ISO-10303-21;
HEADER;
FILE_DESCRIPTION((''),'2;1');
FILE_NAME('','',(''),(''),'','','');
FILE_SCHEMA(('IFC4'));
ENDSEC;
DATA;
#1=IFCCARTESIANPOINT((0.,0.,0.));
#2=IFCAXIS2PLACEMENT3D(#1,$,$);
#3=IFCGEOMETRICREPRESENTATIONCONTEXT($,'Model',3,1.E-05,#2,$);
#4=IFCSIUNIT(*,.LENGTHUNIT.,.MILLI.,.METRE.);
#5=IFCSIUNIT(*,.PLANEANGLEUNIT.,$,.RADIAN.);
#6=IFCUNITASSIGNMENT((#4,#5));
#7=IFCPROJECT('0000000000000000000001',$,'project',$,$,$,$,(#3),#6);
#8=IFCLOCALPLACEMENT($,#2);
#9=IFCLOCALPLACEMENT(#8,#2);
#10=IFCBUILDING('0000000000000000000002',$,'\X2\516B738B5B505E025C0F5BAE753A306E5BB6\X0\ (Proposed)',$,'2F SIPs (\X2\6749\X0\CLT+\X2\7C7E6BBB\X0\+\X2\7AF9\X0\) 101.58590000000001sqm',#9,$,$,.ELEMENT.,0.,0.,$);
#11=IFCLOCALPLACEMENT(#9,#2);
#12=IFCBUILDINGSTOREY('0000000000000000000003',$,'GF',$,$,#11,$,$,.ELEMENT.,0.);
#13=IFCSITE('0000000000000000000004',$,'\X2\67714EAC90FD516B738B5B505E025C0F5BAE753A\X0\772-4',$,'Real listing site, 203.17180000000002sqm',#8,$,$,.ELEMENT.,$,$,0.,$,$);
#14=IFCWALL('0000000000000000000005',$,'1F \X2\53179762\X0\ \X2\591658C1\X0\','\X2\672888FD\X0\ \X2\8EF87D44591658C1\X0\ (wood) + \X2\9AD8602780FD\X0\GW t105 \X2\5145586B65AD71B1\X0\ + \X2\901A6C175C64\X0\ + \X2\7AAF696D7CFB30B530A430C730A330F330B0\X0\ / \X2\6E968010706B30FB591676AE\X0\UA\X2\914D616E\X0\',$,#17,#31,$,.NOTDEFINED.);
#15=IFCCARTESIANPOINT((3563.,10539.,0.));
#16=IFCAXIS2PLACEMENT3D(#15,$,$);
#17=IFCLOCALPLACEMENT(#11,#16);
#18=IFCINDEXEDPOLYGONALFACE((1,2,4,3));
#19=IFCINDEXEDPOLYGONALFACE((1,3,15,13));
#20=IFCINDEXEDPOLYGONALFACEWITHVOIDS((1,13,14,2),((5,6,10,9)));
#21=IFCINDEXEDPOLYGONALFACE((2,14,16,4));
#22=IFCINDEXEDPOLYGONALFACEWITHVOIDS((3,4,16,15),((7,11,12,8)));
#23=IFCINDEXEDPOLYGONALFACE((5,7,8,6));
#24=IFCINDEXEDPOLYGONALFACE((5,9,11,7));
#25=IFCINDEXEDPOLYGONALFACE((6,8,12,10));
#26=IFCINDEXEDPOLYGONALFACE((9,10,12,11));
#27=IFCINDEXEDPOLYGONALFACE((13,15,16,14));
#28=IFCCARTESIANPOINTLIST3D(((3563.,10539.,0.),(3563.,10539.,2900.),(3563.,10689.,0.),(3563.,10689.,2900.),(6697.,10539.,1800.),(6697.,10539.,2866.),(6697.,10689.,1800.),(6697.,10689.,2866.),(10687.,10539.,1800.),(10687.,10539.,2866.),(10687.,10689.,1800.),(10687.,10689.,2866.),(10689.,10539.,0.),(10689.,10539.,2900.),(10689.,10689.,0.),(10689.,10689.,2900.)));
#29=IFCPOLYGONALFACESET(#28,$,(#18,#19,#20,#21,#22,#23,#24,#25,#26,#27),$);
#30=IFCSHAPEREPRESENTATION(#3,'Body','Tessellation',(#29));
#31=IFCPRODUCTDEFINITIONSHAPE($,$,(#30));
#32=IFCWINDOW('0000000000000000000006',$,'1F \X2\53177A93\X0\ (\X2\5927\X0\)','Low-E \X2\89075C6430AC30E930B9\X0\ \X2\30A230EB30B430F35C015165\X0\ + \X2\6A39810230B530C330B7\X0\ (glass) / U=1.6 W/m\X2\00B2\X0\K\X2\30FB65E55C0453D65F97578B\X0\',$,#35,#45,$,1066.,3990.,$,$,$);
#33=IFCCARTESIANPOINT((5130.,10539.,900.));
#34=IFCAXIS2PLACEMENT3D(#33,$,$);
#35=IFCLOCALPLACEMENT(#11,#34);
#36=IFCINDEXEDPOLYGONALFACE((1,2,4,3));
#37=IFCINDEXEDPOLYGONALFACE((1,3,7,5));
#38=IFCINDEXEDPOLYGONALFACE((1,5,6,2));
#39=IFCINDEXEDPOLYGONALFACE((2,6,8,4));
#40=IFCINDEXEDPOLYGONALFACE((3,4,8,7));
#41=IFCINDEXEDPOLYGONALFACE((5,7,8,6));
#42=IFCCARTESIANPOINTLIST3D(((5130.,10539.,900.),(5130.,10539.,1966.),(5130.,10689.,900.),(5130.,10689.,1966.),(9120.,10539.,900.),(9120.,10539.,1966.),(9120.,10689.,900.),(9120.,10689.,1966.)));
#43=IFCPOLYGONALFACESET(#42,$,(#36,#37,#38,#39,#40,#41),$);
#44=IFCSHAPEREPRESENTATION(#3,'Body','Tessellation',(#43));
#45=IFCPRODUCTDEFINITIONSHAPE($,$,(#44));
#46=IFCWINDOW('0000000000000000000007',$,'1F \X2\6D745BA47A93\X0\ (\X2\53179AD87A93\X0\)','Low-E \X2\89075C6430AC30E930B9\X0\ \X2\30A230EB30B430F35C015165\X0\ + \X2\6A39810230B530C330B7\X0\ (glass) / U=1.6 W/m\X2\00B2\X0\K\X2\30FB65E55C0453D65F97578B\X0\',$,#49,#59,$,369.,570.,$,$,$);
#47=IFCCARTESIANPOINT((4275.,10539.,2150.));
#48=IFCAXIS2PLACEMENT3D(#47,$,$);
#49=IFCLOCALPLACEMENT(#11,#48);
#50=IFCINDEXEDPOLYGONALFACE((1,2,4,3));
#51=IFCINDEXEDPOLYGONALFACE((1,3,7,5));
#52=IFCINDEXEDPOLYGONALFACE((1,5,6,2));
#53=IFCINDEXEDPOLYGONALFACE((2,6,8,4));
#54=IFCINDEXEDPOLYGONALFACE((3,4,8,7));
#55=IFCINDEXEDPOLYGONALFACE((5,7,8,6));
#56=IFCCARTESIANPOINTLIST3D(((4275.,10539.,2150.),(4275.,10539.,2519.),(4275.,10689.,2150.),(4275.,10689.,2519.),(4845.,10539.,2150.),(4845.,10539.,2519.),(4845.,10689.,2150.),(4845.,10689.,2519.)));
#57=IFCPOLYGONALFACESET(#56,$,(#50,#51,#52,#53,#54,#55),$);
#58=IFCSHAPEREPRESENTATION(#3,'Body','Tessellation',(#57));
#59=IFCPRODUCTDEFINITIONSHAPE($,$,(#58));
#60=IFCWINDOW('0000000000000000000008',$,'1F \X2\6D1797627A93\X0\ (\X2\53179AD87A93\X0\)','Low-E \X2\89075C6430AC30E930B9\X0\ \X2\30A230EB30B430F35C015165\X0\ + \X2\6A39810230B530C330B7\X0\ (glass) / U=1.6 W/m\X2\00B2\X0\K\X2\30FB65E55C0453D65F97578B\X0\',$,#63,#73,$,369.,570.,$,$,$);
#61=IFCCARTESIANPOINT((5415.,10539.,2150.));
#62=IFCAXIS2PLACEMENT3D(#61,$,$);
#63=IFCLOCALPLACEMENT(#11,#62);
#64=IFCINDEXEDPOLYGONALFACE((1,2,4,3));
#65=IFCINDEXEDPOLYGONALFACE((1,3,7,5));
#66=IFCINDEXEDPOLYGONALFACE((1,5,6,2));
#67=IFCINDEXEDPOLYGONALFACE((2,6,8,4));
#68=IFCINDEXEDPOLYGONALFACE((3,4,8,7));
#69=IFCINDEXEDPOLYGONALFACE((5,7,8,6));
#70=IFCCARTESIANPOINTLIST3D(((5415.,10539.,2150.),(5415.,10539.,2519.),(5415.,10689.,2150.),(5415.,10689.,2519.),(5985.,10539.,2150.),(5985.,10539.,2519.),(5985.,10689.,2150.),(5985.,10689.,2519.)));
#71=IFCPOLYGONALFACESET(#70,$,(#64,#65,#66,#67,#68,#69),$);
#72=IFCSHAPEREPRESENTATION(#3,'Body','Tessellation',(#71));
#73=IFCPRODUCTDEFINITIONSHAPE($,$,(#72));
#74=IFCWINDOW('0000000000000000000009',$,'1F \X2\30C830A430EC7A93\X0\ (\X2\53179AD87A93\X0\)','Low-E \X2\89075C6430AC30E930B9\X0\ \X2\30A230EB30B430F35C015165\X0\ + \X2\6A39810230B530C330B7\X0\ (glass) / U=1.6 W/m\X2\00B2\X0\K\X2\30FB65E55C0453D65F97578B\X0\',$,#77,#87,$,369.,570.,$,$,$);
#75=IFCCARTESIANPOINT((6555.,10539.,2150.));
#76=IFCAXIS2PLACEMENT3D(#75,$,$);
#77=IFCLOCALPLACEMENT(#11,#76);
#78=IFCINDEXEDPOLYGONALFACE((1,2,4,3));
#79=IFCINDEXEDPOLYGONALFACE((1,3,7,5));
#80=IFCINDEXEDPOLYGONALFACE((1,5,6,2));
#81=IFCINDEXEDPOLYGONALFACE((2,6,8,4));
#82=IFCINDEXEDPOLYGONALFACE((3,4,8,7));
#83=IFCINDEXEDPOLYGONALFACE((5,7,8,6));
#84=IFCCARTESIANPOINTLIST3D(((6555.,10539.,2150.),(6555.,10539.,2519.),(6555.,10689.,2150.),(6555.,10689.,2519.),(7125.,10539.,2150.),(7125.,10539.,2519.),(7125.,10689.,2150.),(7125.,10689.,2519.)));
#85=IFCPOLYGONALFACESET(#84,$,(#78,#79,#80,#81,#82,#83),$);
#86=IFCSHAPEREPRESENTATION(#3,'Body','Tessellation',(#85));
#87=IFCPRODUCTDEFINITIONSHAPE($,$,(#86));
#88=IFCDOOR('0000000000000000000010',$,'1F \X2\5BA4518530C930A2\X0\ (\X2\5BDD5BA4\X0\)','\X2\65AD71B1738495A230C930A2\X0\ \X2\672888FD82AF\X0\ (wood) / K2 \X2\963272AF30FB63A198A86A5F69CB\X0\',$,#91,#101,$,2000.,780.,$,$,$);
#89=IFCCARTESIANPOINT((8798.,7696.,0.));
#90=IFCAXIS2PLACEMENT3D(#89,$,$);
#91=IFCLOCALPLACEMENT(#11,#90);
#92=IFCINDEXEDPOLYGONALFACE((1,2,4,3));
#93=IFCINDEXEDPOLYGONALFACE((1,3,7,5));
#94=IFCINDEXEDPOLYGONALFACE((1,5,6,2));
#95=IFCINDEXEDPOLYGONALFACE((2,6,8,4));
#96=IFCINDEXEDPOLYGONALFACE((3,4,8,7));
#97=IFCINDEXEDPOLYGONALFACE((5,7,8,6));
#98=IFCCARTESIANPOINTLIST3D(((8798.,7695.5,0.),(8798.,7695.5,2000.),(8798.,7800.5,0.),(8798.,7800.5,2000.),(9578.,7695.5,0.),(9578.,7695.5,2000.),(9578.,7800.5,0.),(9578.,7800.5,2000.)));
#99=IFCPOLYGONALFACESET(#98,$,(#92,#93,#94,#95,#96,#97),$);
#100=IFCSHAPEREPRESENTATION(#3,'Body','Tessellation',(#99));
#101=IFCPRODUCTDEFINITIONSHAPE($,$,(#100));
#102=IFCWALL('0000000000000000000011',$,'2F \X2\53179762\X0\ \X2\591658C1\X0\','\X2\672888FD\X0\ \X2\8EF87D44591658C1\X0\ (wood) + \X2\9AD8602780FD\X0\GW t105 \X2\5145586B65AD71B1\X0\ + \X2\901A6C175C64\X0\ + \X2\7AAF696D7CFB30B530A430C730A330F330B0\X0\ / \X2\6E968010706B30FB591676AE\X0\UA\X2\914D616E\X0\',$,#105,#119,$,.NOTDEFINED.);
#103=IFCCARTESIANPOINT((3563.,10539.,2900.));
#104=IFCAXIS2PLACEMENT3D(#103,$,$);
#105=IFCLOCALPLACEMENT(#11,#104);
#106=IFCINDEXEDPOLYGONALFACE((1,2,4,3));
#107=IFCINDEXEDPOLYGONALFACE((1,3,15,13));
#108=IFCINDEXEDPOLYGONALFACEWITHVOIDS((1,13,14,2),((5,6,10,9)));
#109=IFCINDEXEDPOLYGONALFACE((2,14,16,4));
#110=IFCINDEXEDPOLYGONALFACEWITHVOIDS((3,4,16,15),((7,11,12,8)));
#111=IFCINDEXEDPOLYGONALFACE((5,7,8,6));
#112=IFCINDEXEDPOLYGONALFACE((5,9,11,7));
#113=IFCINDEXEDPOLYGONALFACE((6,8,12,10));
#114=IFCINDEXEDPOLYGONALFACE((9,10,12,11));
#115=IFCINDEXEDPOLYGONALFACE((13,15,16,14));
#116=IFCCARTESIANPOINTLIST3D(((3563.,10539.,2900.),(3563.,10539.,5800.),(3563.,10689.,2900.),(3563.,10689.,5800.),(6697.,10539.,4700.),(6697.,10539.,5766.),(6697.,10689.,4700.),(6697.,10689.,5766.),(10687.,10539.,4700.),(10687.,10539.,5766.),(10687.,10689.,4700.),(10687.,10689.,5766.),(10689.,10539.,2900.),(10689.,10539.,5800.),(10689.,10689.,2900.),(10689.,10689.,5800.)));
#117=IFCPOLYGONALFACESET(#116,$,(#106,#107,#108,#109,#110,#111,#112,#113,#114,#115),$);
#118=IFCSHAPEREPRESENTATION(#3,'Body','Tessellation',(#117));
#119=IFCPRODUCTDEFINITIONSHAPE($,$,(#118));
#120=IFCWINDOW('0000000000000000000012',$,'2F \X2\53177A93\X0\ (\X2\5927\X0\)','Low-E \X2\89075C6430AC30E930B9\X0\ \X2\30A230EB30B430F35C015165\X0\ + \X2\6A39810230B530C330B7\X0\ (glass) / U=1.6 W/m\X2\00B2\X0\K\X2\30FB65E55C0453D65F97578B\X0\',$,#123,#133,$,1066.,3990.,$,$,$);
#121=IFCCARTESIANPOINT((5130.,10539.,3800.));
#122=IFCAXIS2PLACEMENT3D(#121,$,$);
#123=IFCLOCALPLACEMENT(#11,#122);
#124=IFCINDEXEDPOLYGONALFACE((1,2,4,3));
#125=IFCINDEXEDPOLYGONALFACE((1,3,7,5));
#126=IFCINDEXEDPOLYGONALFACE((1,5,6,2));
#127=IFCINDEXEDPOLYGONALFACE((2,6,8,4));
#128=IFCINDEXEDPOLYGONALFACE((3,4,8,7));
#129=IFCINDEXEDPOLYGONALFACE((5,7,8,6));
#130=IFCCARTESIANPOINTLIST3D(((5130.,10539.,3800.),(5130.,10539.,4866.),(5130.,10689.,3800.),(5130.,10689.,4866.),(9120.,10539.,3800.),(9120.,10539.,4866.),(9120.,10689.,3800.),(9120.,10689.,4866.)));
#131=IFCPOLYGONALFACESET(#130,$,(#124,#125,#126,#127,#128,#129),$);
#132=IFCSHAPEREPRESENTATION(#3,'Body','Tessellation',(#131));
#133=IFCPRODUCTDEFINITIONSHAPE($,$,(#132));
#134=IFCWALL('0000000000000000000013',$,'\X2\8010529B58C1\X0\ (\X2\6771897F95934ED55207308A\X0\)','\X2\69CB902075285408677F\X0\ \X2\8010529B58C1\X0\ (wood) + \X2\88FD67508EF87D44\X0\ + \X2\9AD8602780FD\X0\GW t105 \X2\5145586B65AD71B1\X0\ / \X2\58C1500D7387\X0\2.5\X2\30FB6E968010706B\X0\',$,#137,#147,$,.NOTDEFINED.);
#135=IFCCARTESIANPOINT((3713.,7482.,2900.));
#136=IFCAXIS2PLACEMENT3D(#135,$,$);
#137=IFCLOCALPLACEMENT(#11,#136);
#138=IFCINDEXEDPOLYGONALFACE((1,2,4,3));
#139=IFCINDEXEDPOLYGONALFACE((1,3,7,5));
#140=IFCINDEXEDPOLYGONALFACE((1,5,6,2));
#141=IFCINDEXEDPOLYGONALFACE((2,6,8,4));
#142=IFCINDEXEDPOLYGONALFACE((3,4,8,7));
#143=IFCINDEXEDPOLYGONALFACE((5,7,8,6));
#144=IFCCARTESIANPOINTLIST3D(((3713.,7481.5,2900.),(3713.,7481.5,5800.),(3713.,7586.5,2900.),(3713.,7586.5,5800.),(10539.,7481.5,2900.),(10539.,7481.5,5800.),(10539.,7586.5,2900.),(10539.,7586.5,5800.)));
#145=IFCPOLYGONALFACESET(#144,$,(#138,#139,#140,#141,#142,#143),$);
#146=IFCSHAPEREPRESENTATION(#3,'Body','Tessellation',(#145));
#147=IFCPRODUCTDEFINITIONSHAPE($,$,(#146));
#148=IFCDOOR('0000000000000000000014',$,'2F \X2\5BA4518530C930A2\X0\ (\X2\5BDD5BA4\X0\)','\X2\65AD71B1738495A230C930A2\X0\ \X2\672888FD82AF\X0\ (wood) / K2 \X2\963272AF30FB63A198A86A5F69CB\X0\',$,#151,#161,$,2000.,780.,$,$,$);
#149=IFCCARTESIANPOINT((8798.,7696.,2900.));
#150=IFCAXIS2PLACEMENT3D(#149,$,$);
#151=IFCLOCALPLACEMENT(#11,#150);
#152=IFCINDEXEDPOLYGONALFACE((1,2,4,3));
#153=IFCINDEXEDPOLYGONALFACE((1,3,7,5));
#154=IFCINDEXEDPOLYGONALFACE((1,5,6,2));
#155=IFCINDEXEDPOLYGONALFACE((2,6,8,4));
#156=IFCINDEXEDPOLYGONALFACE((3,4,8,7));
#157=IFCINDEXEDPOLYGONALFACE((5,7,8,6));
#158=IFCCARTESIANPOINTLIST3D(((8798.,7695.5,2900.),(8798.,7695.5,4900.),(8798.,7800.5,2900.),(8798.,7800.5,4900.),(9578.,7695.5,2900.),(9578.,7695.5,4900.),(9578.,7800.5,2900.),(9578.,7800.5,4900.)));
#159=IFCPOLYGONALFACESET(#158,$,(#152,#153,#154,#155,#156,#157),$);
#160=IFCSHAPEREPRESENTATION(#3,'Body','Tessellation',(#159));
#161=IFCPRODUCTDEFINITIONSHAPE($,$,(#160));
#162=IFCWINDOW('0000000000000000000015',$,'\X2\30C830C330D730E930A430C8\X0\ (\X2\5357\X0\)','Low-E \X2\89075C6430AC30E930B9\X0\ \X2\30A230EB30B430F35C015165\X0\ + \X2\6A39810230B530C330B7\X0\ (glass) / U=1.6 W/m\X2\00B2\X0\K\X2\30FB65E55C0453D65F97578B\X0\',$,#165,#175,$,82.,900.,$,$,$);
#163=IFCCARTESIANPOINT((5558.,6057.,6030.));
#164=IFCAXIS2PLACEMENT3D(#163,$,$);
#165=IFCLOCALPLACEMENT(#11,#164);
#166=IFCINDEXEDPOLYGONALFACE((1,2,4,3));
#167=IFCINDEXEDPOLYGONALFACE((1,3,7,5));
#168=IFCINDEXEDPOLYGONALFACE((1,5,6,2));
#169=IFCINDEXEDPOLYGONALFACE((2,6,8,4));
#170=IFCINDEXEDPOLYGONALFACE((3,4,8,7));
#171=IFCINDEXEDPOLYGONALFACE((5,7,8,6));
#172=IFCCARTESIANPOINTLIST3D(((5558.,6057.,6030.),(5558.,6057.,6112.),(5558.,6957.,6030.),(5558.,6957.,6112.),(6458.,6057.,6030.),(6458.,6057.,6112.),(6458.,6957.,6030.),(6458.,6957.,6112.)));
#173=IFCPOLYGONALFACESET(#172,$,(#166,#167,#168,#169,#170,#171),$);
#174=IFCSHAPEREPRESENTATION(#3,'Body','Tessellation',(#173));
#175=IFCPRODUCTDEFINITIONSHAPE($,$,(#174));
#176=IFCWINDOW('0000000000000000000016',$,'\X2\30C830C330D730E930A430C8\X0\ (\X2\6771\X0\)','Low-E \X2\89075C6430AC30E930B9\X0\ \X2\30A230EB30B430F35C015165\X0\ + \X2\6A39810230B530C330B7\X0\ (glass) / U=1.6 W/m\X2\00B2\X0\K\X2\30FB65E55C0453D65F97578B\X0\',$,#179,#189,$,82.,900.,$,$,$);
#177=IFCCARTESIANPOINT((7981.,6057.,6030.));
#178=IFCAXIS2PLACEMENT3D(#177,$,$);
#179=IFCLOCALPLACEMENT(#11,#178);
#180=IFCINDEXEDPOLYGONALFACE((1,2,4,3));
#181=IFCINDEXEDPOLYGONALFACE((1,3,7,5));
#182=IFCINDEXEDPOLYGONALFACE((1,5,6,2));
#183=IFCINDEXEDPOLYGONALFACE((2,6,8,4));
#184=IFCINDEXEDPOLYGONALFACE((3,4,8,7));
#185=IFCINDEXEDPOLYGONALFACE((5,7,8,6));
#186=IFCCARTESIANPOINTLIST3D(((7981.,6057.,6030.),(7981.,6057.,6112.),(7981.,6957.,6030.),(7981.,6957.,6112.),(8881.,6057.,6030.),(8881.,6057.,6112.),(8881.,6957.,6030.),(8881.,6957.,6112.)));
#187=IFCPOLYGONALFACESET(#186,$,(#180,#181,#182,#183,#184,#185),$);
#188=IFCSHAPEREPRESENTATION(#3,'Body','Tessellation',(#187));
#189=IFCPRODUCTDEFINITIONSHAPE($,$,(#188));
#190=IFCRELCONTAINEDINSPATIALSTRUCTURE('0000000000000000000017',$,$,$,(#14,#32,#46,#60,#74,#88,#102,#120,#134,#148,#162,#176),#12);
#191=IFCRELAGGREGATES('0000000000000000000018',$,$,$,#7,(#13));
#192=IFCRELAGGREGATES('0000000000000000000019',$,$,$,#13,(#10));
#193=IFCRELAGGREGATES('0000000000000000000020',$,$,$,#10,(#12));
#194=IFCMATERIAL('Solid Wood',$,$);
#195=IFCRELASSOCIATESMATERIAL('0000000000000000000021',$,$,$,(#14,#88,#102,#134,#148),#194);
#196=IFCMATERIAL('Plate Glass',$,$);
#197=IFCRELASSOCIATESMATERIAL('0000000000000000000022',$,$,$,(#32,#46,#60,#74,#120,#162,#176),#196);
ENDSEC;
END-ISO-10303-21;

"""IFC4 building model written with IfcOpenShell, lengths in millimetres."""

from ifc_helpers import new_model, si_unit, frame, frame_2d, origin, place, context, project, spatial, rectangle, extrude, material, element, fill, save


model = new_model("IFC4")

# Units and contexts
model_context = context("Model", 3, precision=1e-05, world=origin())
ifc_project = project(units=[si_unit("LENGTHUNIT", "METRE", prefix="MILLI"), si_unit("PLANEANGLEUNIT", "RADIAN")], contexts=[model_context])

# Site, building, storey
site_placement = place(None, origin())
site = spatial("IfcSite", under=ifc_project, at=site_placement, Name="東京都八王子市小宮町772-4", ObjectType="Real listing site, 203.17180000000002sqm", CompositionType="ELEMENT", RefElevation=0.0)
building_placement = place(site_placement, origin())
building = spatial("IfcBuilding", under=site, at=building_placement, Name="八王子市小宮町の家 (Proposed)", ObjectType="2F SIPs (杉CLT+籾殻+竹) 101.58590000000001sqm", CompositionType="ELEMENT", ElevationOfRefHeight=0.0, ElevationOfTerrain=0.0)
storey_placement = place(building_placement, origin())
storey = spatial("IfcBuildingStorey", under=building, at=storey_placement, Name="GF", CompositionType="ELEMENT", Elevation=0.0)

# Wall, openings, windows
ifc_material_1 = material(Name="Solid Wood")
wall_1_placement = place(storey_placement, frame((3563.0, 10539.0, 0.0)))
wall_1 = element("IfcWall", 1, at=wall_1_placement, inside=storey, material=ifc_material_1, Name="1F 北面 外壁", Description="木製 軸組外壁 (wood) + 高性能GW t105 充填断熱 + 通気層 + 窯業系サイディング / 準耐火・外皮UA配慮", PredefinedType="NOTDEFINED", context=model_context, shape_type="SweptSolid", body=[
    extrude(rectangle(XDim=7126.0, YDim=150.0, at=frame_2d((3563.0, 75.0))), frame((3563.0, 10539.0, 0.0)), (0.0, 0.0, 1.0), 2900.0),
])
opening_1_placement = place(storey_placement, frame((5130.0, 10539.0, 900.0)))
opening_1 = element("IfcOpeningElement", 2, at=opening_1_placement, cuts=wall_1, PredefinedType="NOTDEFINED", context=model_context, shape_type="SweptSolid", body=[
    extrude(rectangle(XDim=3990.0, YDim=150.0, at=frame_2d((1995.0, 75.0))), frame((5130.0, 10539.0, 900.0)), (0.0, 0.0, 1.0), 1066.0),
])
opening_2_placement = place(storey_placement, frame((4275.0, 10539.0, 2150.0)))
opening_2 = element("IfcOpeningElement", 3, at=opening_2_placement, cuts=wall_1, PredefinedType="NOTDEFINED", context=model_context, shape_type="SweptSolid", body=[
    extrude(rectangle(XDim=570.0, YDim=150.0, at=frame_2d((285.0, 75.0))), frame((4275.0, 10539.0, 2150.0)), (0.0, 0.0, 1.0), 369.0),
])
opening_3_placement = place(storey_placement, frame((5415.0, 10539.0, 2150.0)))
opening_3 = element("IfcOpeningElement", 4, at=opening_3_placement, cuts=wall_1, PredefinedType="NOTDEFINED", context=model_context, shape_type="SweptSolid", body=[
    extrude(rectangle(XDim=570.0, YDim=150.0, at=frame_2d((285.0, 75.0))), frame((5415.0, 10539.0, 2150.0)), (0.0, 0.0, 1.0), 369.0),
])
opening_4_placement = place(storey_placement, frame((6555.0, 10539.0, 2150.0)))
opening_4 = element("IfcOpeningElement", 5, at=opening_4_placement, cuts=wall_1, PredefinedType="NOTDEFINED", context=model_context, shape_type="SweptSolid", body=[
    extrude(rectangle(XDim=570.0, YDim=150.0, at=frame_2d((285.0, 75.0))), frame((6555.0, 10539.0, 2150.0)), (0.0, 0.0, 1.0), 369.0),
])
ifc_material_2 = material(Name="Plate Glass")
window_1_placement = place(storey_placement, frame((5130.0, 10539.0, 900.0)))
window_1 = element("IfcWindow", 6, at=window_1_placement, inside=storey, material=ifc_material_2, Name="1F 北窓 (大)", Description="Low-E 複層ガラス アルゴン封入 + 樹脂サッシ (glass) / U=1.6 W/m²K・日射取得型", OverallHeight=1066.0, OverallWidth=3990.0, context=model_context, shape_type="SweptSolid", body=[
    extrude(rectangle(XDim=3990.0, YDim=150.0, at=frame_2d((1995.0, 75.0))), frame((5130.0, 10539.0, 900.0)), (0.0, 0.0, 1.0), 1066.0),
])
fill(opening_1, window_1)
window_2_placement = place(storey_placement, frame((4275.0, 10539.0, 2150.0)))
window_2 = element("IfcWindow", 7, at=window_2_placement, inside=storey, material=ifc_material_2, Name="1F 浴室窓 (北高窓)", Description="Low-E 複層ガラス アルゴン封入 + 樹脂サッシ (glass) / U=1.6 W/m²K・日射取得型", OverallHeight=369.0, OverallWidth=570.0, context=model_context, shape_type="SweptSolid", body=[
    extrude(rectangle(XDim=570.0, YDim=150.0, at=frame_2d((285.0, 75.0))), frame((4275.0, 10539.0, 2150.0)), (0.0, 0.0, 1.0), 369.0),
])
fill(opening_2, window_2)
window_3_placement = place(storey_placement, frame((5415.0, 10539.0, 2150.0)))
window_3 = element("IfcWindow", 8, at=window_3_placement, inside=storey, material=ifc_material_2, Name="1F 洗面窓 (北高窓)", Description="Low-E 複層ガラス アルゴン封入 + 樹脂サッシ (glass) / U=1.6 W/m²K・日射取得型", OverallHeight=369.0, OverallWidth=570.0, context=model_context, shape_type="SweptSolid", body=[
    extrude(rectangle(XDim=570.0, YDim=150.0, at=frame_2d((285.0, 75.0))), frame((5415.0, 10539.0, 2150.0)), (0.0, 0.0, 1.0), 369.0),
])
fill(opening_3, window_3)
window_4_placement = place(storey_placement, frame((6555.0, 10539.0, 2150.0)))
window_4 = element("IfcWindow", 9, at=window_4_placement, inside=storey, material=ifc_material_2, Name="1F トイレ窓 (北高窓)", Description="Low-E 複層ガラス アルゴン封入 + 樹脂サッシ (glass) / U=1.6 W/m²K・日射取得型", OverallHeight=369.0, OverallWidth=570.0, context=model_context, shape_type="SweptSolid", body=[
    extrude(rectangle(XDim=570.0, YDim=150.0, at=frame_2d((285.0, 75.0))), frame((6555.0, 10539.0, 2150.0)), (0.0, 0.0, 1.0), 369.0),
])
fill(opening_4, window_4)

# Door
door_1_placement = place(storey_placement, frame((8798.0, 7696.0, 0.0)))
element("IfcDoor", 10, at=door_1_placement, inside=storey, material=ifc_material_1, Name="1F 室内ドア (寝室)", Description="断熱玄関ドア 木製芯 (wood) / K2 防犯・採風機構", OverallHeight=2000.0, OverallWidth=780.0, context=model_context, shape_type="SweptSolid", body=[
    extrude(rectangle(XDim=780.0, YDim=105.0, at=frame_2d((390.0, 52.0))), frame((8798.0, 7696.0, 0.0)), (0.0, 0.0, 1.0), 2000.0),
])

# Wall, opening, window
wall_2_placement = place(storey_placement, frame((3563.0, 10539.0, 2900.0)))
wall_2 = element("IfcWall", 11, at=wall_2_placement, inside=storey, material=ifc_material_1, Name="2F 北面 外壁", Description="木製 軸組外壁 (wood) + 高性能GW t105 充填断熱 + 通気層 + 窯業系サイディング / 準耐火・外皮UA配慮", PredefinedType="NOTDEFINED", context=model_context, shape_type="SweptSolid", body=[
    extrude(rectangle(XDim=7126.0, YDim=150.0, at=frame_2d((3563.0, 75.0))), frame((3563.0, 10539.0, 2900.0)), (0.0, 0.0, 1.0), 2900.0),
])
opening_5_placement = place(storey_placement, frame((5130.0, 10539.0, 3800.0)))
opening_5 = element("IfcOpeningElement", 12, at=opening_5_placement, cuts=wall_2, PredefinedType="NOTDEFINED", context=model_context, shape_type="SweptSolid", body=[
    extrude(rectangle(XDim=3990.0, YDim=150.0, at=frame_2d((1995.0, 75.0))), frame((5130.0, 10539.0, 3800.0)), (0.0, 0.0, 1.0), 1066.0),
])
window_5_placement = place(storey_placement, frame((5130.0, 10539.0, 3800.0)))
window_5 = element("IfcWindow", 13, at=window_5_placement, inside=storey, material=ifc_material_2, Name="2F 北窓 (大)", Description="Low-E 複層ガラス アルゴン封入 + 樹脂サッシ (glass) / U=1.6 W/m²K・日射取得型", OverallHeight=1066.0, OverallWidth=3990.0, context=model_context, shape_type="SweptSolid", body=[
    extrude(rectangle(XDim=3990.0, YDim=150.0, at=frame_2d((1995.0, 75.0))), frame((5130.0, 10539.0, 3800.0)), (0.0, 0.0, 1.0), 1066.0),
])
fill(opening_5, window_5)

# Wall
wall_3_placement = place(storey_placement, frame((3713.0, 7482.0, 2900.0)))
element("IfcWall", 14, at=wall_3_placement, inside=storey, material=ifc_material_1, Name="耐力壁 (東西間仕切り)", Description="構造用合板 耐力壁 (wood) + 製材軸組 + 高性能GW t105 充填断熱 / 壁倍率2.5・準耐火", PredefinedType="NOTDEFINED", context=model_context, shape_type="SweptSolid", body=[
    extrude(rectangle(XDim=6826.0, YDim=105.0, at=frame_2d((3413.0, 52.0))), frame((3713.0, 7482.0, 2900.0)), (0.0, 0.0, 1.0), 2900.0),
])

# Door
door_2_placement = place(storey_placement, frame((8798.0, 7696.0, 2900.0)))
element("IfcDoor", 15, at=door_2_placement, inside=storey, material=ifc_material_1, Name="2F 室内ドア (寝室)", Description="断熱玄関ドア 木製芯 (wood) / K2 防犯・採風機構", OverallHeight=2000.0, OverallWidth=780.0, context=model_context, shape_type="SweptSolid", body=[
    extrude(rectangle(XDim=780.0, YDim=105.0, at=frame_2d((390.0, 52.0))), frame((8798.0, 7696.0, 2900.0)), (0.0, 0.0, 1.0), 2000.0),
])

# Windows
window_6_placement = place(storey_placement, frame((5558.0, 6057.0, 6030.0)))
element("IfcWindow", 16, at=window_6_placement, inside=storey, material=ifc_material_2, Name="トップライト (南)", Description="Low-E 複層ガラス アルゴン封入 + 樹脂サッシ (glass) / U=1.6 W/m²K・日射取得型", OverallHeight=82.0, OverallWidth=900.0, context=model_context, shape_type="SweptSolid", body=[
    extrude(rectangle(XDim=900.0, YDim=900.0, at=frame_2d((450.0, 450.0))), frame((5558.0, 6057.0, 6030.0)), (0.0, 0.0, 1.0), 82.0),
])
window_7_placement = place(storey_placement, frame((7981.0, 6057.0, 6030.0)))
element("IfcWindow", 17, at=window_7_placement, inside=storey, material=ifc_material_2, Name="トップライト (東)", Description="Low-E 複層ガラス アルゴン封入 + 樹脂サッシ (glass) / U=1.6 W/m²K・日射取得型", OverallHeight=82.0, OverallWidth=900.0, context=model_context, shape_type="SweptSolid", body=[
    extrude(rectangle(XDim=900.0, YDim=900.0, at=frame_2d((450.0, 450.0))), frame((7981.0, 6057.0, 6030.0)), (0.0, 0.0, 1.0), 82.0),
])

save(model, "model.ifc")
